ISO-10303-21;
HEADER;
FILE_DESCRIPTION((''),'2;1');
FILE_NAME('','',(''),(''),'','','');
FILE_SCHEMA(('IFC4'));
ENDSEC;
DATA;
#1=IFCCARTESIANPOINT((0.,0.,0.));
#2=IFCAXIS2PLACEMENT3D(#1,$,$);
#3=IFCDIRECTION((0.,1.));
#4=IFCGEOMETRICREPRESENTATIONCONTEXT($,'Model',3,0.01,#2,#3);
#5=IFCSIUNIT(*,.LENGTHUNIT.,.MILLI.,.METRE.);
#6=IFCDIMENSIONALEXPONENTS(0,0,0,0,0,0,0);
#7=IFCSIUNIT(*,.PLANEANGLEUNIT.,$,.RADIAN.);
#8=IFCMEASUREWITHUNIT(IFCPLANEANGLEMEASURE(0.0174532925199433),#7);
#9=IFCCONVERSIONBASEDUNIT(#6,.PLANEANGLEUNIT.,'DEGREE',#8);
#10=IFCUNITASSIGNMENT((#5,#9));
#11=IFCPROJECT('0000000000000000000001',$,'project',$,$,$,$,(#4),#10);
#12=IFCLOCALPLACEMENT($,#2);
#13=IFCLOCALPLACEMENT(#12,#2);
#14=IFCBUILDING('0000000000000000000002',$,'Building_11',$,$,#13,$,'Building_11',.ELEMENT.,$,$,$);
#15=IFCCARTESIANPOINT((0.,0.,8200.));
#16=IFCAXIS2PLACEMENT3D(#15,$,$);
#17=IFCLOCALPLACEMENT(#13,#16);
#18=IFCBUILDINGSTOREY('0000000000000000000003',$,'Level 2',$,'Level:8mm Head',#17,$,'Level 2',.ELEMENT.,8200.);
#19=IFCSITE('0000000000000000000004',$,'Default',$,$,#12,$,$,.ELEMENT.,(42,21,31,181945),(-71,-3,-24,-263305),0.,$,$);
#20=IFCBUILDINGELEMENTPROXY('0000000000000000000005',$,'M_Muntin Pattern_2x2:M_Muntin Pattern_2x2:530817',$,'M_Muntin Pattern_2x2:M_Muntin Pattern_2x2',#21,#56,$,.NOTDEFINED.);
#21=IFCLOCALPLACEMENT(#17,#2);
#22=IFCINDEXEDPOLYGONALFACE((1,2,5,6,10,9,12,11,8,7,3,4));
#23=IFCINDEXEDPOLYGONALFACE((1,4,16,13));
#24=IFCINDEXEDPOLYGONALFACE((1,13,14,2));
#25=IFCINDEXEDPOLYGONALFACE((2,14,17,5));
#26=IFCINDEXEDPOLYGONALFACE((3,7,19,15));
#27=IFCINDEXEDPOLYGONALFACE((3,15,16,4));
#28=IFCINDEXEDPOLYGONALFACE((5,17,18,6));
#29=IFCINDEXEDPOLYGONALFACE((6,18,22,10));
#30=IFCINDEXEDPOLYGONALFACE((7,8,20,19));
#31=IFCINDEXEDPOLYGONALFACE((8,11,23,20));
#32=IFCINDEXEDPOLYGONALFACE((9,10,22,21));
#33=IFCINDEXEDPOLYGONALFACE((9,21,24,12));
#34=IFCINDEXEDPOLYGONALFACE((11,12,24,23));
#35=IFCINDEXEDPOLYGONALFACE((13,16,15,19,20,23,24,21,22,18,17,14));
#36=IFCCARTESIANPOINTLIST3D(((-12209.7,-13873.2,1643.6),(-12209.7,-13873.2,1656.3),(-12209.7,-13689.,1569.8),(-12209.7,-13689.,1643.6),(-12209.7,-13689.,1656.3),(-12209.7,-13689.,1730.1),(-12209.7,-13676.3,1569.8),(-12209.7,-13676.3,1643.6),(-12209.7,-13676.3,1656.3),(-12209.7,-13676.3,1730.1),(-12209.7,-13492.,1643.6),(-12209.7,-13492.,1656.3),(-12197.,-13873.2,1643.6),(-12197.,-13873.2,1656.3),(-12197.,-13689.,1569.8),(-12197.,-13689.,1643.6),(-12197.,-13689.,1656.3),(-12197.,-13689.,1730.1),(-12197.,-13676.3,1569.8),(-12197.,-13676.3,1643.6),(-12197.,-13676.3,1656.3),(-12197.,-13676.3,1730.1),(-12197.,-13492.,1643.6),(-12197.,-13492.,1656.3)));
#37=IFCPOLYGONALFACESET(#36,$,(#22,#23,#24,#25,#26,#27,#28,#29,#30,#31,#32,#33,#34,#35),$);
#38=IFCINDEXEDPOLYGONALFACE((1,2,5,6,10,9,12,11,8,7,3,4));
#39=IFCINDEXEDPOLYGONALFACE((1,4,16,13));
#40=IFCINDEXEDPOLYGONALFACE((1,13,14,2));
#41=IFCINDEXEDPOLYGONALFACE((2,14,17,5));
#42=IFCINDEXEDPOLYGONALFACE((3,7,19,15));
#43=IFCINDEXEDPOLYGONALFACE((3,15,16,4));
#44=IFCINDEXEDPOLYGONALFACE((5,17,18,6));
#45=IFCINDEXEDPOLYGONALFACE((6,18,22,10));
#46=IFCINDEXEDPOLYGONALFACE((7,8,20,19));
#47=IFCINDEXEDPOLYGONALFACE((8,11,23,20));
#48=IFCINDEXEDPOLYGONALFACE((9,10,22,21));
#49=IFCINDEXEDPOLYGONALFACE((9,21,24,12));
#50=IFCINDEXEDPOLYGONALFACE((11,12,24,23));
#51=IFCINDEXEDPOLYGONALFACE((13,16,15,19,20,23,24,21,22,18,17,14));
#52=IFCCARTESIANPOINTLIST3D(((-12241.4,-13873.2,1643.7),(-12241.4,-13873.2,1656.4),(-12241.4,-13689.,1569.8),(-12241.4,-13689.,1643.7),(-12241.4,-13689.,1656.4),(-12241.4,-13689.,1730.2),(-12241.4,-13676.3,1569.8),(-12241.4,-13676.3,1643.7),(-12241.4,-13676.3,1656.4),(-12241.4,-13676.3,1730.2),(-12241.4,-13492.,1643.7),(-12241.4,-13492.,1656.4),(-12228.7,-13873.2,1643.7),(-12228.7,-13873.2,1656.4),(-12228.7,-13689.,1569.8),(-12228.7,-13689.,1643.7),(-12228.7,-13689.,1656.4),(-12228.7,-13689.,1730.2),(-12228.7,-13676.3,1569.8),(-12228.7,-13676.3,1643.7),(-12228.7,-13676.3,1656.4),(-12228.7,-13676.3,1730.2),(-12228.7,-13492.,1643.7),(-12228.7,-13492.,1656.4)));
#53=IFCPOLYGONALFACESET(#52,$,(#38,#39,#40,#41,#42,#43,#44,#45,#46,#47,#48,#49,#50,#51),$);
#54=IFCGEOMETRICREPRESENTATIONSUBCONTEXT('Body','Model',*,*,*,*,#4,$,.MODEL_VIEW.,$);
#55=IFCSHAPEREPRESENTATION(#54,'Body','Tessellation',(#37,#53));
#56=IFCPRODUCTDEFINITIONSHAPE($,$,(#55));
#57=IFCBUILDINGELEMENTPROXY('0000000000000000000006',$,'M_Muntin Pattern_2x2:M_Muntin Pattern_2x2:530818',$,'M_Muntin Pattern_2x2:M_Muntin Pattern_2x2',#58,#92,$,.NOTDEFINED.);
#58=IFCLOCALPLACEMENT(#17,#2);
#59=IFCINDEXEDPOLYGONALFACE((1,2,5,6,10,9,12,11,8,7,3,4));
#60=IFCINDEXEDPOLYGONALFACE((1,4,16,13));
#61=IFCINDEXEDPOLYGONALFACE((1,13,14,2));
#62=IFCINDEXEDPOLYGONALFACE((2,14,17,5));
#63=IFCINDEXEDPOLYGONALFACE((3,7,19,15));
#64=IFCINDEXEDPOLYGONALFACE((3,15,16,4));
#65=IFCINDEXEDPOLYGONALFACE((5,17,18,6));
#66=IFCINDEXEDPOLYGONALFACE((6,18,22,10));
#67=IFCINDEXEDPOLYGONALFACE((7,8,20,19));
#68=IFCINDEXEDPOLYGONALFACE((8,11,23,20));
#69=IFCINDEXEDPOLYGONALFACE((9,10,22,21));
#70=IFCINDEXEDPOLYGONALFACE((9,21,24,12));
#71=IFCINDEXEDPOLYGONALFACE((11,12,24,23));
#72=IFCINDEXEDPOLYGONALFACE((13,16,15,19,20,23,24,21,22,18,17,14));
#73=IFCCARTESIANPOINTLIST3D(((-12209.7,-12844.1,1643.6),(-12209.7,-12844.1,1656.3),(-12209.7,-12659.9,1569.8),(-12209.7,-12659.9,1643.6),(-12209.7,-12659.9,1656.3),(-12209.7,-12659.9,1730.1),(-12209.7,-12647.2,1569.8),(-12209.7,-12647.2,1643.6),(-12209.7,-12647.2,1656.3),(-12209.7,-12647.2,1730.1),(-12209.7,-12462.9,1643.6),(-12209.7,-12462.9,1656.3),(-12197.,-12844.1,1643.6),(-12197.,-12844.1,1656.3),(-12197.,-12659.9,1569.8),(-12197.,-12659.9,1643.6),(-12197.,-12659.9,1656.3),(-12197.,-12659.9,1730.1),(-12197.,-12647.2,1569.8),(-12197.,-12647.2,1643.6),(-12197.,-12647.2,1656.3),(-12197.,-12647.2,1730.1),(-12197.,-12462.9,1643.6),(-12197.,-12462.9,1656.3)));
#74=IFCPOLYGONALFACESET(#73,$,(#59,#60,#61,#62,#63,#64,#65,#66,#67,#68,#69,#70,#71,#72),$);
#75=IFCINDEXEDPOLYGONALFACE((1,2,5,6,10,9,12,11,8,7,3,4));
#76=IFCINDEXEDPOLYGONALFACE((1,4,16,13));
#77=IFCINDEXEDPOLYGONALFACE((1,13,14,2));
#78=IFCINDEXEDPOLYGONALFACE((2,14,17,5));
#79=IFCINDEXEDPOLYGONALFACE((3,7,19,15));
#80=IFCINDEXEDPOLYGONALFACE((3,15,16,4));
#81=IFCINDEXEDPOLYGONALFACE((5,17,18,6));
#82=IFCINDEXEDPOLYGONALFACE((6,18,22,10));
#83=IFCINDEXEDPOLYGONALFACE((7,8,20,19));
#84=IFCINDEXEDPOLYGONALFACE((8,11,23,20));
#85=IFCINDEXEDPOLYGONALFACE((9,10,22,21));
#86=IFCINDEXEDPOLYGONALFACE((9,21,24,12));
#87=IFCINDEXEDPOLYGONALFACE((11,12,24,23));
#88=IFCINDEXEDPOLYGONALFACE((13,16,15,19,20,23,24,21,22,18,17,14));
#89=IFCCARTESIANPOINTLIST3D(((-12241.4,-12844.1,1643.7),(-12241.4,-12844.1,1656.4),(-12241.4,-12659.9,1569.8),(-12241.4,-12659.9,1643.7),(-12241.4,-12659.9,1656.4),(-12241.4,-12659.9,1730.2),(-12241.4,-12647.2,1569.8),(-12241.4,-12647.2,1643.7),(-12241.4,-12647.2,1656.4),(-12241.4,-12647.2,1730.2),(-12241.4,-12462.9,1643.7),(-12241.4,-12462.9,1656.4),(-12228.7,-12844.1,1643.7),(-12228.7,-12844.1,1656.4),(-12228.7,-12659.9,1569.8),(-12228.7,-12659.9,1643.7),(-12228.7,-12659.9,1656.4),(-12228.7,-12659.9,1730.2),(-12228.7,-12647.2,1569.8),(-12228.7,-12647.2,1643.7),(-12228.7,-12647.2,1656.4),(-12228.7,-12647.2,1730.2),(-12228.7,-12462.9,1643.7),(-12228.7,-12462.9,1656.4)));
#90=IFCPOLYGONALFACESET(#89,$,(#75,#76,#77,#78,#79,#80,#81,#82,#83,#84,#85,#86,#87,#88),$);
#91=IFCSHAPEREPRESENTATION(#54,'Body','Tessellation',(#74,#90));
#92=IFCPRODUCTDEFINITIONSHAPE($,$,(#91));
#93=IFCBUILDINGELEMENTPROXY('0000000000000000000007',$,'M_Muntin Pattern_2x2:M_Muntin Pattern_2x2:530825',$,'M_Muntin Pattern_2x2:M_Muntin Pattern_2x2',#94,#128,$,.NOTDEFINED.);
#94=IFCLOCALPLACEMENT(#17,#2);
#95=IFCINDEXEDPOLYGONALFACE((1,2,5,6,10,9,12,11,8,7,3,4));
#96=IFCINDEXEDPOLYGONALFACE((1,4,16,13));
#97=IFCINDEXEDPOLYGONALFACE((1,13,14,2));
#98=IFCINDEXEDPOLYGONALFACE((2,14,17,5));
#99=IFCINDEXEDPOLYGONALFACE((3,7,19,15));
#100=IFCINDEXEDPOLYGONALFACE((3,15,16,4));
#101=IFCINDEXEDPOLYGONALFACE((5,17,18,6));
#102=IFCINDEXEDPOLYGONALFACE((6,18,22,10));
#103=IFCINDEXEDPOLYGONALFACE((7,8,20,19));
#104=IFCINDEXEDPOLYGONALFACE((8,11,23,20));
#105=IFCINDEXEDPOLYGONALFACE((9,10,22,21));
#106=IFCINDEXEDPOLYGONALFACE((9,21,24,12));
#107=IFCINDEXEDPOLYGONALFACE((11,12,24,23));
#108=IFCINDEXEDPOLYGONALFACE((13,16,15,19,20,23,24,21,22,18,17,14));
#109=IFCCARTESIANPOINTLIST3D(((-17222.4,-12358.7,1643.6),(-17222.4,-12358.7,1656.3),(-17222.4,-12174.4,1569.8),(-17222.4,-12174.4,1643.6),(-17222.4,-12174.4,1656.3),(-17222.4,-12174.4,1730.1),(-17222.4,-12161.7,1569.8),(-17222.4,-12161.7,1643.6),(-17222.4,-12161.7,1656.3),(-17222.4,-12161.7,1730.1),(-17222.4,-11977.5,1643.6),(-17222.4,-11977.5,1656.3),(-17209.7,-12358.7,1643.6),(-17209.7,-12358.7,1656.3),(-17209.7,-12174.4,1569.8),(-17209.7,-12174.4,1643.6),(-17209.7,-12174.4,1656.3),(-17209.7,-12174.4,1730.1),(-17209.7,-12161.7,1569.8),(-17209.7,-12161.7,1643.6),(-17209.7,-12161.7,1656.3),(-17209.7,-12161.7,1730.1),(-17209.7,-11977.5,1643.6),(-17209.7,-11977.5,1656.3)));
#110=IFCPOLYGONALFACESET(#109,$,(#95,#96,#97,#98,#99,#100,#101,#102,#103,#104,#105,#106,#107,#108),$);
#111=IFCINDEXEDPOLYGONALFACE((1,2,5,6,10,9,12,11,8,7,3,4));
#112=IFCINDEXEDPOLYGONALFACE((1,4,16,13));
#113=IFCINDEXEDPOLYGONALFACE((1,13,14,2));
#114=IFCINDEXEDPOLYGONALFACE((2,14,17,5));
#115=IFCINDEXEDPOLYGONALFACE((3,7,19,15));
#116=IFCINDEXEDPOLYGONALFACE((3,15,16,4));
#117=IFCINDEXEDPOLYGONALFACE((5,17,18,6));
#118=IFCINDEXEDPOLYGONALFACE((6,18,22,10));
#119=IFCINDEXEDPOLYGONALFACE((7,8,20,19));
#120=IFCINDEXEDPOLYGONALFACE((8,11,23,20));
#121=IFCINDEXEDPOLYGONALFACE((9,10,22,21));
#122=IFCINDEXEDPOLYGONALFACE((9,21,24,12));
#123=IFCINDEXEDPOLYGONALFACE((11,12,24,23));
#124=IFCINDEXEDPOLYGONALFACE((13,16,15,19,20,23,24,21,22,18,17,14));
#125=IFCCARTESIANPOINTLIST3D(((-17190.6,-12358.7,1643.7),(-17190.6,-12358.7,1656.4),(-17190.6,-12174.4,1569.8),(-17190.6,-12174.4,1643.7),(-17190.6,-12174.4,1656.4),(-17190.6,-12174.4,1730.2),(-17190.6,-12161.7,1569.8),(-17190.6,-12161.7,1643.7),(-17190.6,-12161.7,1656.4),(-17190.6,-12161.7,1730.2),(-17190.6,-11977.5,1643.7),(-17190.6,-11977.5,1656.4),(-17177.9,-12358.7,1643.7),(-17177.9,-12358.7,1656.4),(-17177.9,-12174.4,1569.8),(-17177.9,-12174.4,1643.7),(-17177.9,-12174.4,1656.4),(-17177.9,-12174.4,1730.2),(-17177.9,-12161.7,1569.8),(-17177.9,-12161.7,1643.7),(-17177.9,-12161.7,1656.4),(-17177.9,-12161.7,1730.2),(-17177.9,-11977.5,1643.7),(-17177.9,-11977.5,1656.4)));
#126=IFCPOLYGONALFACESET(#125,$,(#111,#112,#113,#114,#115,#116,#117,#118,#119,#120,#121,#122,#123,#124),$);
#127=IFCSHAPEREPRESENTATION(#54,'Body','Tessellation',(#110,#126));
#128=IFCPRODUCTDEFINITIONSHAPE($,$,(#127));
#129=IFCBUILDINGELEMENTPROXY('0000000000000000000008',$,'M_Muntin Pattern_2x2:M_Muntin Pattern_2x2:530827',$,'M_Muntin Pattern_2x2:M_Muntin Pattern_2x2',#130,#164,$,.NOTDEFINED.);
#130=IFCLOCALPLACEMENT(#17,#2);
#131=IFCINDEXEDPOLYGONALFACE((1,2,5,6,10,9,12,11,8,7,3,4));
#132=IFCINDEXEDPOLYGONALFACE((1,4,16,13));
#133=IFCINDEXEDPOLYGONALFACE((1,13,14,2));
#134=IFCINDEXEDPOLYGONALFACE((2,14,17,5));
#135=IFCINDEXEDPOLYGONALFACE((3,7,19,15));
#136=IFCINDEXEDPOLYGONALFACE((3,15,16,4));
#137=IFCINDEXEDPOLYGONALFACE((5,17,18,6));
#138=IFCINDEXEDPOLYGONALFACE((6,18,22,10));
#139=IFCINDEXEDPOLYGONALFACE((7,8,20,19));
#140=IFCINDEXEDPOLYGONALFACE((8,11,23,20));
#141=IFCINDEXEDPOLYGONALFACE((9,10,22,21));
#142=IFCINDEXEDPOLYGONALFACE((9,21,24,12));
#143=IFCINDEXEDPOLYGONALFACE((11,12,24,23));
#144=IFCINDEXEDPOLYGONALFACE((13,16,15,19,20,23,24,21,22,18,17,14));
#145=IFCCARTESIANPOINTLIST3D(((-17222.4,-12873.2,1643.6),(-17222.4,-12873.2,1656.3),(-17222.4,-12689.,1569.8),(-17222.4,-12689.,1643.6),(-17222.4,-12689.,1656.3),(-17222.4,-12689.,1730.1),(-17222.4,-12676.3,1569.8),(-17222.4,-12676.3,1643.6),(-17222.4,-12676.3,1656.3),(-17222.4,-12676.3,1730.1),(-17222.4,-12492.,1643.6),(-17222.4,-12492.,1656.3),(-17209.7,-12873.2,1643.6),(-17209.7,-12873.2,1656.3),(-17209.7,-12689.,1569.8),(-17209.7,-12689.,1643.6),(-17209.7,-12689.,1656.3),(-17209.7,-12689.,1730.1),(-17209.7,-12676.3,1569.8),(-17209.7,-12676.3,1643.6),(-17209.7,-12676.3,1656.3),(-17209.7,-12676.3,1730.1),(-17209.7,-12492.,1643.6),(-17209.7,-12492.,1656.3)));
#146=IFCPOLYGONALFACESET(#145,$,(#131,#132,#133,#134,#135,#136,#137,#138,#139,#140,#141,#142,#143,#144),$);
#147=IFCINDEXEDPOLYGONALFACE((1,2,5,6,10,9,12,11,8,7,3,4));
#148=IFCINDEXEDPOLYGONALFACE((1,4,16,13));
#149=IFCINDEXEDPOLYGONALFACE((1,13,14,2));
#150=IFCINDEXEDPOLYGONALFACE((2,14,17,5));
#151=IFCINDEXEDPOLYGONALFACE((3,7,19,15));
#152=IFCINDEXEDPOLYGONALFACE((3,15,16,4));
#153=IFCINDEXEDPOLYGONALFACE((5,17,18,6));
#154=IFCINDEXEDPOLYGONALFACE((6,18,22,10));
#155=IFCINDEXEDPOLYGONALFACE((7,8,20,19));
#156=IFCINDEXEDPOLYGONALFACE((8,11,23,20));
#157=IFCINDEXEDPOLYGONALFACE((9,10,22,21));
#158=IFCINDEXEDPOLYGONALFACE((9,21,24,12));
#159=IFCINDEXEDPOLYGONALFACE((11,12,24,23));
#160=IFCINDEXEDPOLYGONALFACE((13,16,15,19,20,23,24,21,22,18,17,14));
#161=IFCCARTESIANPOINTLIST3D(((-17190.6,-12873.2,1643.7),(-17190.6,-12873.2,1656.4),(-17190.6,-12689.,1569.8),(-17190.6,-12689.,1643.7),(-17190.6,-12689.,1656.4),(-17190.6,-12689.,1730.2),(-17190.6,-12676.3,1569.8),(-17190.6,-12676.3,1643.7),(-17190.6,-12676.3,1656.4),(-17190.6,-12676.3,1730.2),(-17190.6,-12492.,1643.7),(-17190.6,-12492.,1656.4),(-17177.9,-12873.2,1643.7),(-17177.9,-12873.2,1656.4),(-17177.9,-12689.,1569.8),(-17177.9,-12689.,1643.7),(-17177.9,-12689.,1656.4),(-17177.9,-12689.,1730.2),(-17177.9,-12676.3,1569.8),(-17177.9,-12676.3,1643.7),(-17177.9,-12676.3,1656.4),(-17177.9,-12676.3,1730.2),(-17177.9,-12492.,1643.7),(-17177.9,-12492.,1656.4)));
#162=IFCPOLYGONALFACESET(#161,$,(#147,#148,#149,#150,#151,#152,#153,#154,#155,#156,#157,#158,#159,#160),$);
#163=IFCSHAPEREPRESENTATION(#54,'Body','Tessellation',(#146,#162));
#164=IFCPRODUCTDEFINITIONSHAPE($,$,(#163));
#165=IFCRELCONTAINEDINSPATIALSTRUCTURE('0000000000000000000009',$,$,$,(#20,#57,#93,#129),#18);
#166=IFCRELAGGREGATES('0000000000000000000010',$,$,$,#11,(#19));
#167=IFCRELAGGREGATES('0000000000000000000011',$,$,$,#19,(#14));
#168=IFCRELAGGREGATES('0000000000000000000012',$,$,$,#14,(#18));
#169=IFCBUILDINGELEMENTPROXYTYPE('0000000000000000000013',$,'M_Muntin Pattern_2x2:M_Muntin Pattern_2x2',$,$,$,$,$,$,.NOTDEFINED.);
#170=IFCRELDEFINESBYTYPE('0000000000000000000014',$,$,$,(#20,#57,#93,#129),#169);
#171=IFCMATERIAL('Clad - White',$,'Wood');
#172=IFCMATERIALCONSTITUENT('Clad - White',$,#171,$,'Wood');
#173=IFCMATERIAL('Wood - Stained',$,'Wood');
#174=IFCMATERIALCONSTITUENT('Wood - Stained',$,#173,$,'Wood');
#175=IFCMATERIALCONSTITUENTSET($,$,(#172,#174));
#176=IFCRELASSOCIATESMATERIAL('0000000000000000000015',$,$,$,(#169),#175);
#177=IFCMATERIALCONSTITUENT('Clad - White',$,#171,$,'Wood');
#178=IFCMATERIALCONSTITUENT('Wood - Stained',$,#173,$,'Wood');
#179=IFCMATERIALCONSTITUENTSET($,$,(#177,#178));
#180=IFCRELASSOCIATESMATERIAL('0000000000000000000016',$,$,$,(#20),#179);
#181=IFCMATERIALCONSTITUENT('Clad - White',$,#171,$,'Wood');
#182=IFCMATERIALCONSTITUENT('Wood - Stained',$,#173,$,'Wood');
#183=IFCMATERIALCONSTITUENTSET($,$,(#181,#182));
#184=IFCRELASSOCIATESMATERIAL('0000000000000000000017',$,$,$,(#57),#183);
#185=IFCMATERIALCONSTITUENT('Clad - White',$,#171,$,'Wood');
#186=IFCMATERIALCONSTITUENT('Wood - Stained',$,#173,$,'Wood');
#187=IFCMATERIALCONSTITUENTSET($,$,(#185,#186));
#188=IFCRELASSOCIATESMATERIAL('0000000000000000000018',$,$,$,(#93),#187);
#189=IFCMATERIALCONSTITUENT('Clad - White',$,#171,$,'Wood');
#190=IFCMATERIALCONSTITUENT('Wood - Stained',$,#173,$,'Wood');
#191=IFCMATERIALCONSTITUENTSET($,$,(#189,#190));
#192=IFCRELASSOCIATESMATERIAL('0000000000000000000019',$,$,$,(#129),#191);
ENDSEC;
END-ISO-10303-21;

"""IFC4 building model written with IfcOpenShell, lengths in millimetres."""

from ifc_helpers import new_model, entity, si_unit, converted_unit, direction, frame, origin, place, context, subcontext, project, spatial, indexed_curve, outline, extrude, source, transform, mapped, material, constituent, constituent_set, type_object, type_shapes, element, save


model = new_model("IFC4")

# Units and contexts
model_context = context("Model", 3, precision=0.01, world=origin(), true_north=direction((0.0, 1.0)))
body_context = subcontext(model_context, "Body", "Model", "MODEL_VIEW")
ifc_project = project(units=[si_unit("LENGTHUNIT", "METRE", prefix="MILLI"), converted_unit("PLANEANGLEUNIT", "DEGREE", entity("IfcPlaneAngleMeasure", 0.0174532925199433), si_unit("PLANEANGLEUNIT", "RADIAN"), dimensions=[0, 0, 0, 0, 0, 0, 0])], contexts=[model_context])

# Site, building, storey
site_placement = place(None, origin())
site = spatial("IfcSite", under=ifc_project, at=site_placement, Name="Default", CompositionType="ELEMENT", RefLatitude=(42, 21, 31, 181945), RefLongitude=(-71, -3, -24, -263305), RefElevation=0.0)
building_placement = place(site_placement, origin())
building = spatial("IfcBuilding", under=site, at=building_placement, Name="Building_11", LongName="Building_11", CompositionType="ELEMENT")
storey_placement = place(building_placement, frame((0.0, 0.0, 8200.0)))
storey = spatial("IfcBuildingStorey", under=building, at=storey_placement, Name="Level 2", ObjectType="Level:8mm Head", LongName="Level 2", CompositionType="ELEMENT", Elevation=8200.0)

# Building element proxies
ifc_material_1 = material(Name="Clad - White", Category="Wood")
ifc_material_2 = material(Name="Wood - Stained", Category="Wood")
ifc_constituent_1 = constituent(ifc_material_1, Name="Clad - White", Category="Wood")
ifc_constituent_2 = constituent(ifc_material_2, Name="Wood - Stained", Category="Wood")
ifc_constituent_set_1 = constituent_set(constituents=[ifc_constituent_1, ifc_constituent_2])
building_element_proxy_type_1 = type_object("IfcBuildingElementProxyType", Name="M_Muntin Pattern_2x2:M_Muntin Pattern_2x2", PredefinedType="NOTDEFINED", material=ifc_constituent_set_1)
shared_shape_1 = source(origin(), body_context, "Body", "SweptSolid", [
    extrude(outline(indexed_curve([(6.4, -6.4), (80.1, -6.4), (80.1, 6.3), (6.4, 6.3), (6.4, 190.6), (-6.3, 190.6), (-6.3, 6.3), (-80.2, 6.3), (-80.2, -6.4), (-6.3, -6.4), (-6.3, -190.6), (6.4, -190.6), (6.4, -6.4)], self_intersect=False)), frame((0.0, 9.5, 80.1), z_axis=(0.0, 1.0, 0.0), x_axis=(0.0, 0.0, 1.0)), (0.0, 0.0, 1.0), 12.7),
    extrude(outline(indexed_curve([(6.4, -6.4), (80.2, -6.4), (80.2, 6.3), (6.4, 6.3), (6.4, 190.6), (-6.3, 190.6), (-6.3, 6.3), (-80.2, 6.3), (-80.2, -6.4), (-6.3, -6.4), (-6.3, -190.6), (6.4, -190.6), (6.4, -6.4)], self_intersect=False)), frame((0.0, -22.2, 80.2), z_axis=(0.0, 1.0, 0.0), x_axis=(0.0, 0.0, 1.0)), (0.0, 0.0, 1.0), 12.7),
])
type_shapes(building_element_proxy_type_1, [shared_shape_1])
ifc_constituent_3 = constituent(ifc_material_1, Name="Clad - White", Category="Wood")
ifc_constituent_4 = constituent(ifc_material_2, Name="Wood - Stained", Category="Wood")
ifc_constituent_set_2 = constituent_set(constituents=[ifc_constituent_3, ifc_constituent_4])
proxy_1_placement = place(storey_placement, frame((-12219.2, -13682.6, 1569.8), z_axis=(0.0, 0.0, 1.0), x_axis=(0.0, -1.0, 0.0)))
element("IfcBuildingElementProxy", 1, at=proxy_1_placement, inside=storey, type_object=building_element_proxy_type_1, material=ifc_constituent_set_2, Name="M_Muntin Pattern_2x2:M_Muntin Pattern_2x2:530817", ObjectType="M_Muntin Pattern_2x2:M_Muntin Pattern_2x2", PredefinedType="NOTDEFINED", context=body_context, shape_type="MappedRepresentation", body=[
    mapped(shared_shape_1, transform((0.0, 0.0, 0.0), scale=1.0)),
])
ifc_constituent_5 = constituent(ifc_material_1, Name="Clad - White", Category="Wood")
ifc_constituent_6 = constituent(ifc_material_2, Name="Wood - Stained", Category="Wood")
ifc_constituent_set_3 = constituent_set(constituents=[ifc_constituent_5, ifc_constituent_6])
proxy_2_placement = place(storey_placement, frame((-12219.2, -12653.5, 1569.8), z_axis=(0.0, 0.0, 1.0), x_axis=(0.0, -1.0, 0.0)))
element("IfcBuildingElementProxy", 2, at=proxy_2_placement, inside=storey, type_object=building_element_proxy_type_1, material=ifc_constituent_set_3, Name="M_Muntin Pattern_2x2:M_Muntin Pattern_2x2:530818", ObjectType="M_Muntin Pattern_2x2:M_Muntin Pattern_2x2", PredefinedType="NOTDEFINED", context=body_context, shape_type="MappedRepresentation", body=[
    mapped(shared_shape_1, transform((0.0, 0.0, 0.0), scale=1.0)),
])
ifc_constituent_7 = constituent(ifc_material_1, Name="Clad - White", Category="Wood")
ifc_constituent_8 = constituent(ifc_material_2, Name="Wood - Stained", Category="Wood")
ifc_constituent_set_4 = constituent_set(constituents=[ifc_constituent_7, ifc_constituent_8])
proxy_3_placement = place(storey_placement, frame((-17200.2, -12168.1, 1569.8), z_axis=(0.0, 0.0, 1.0), x_axis=(0.0, 1.0, 0.0)))
element("IfcBuildingElementProxy", 3, at=proxy_3_placement, inside=storey, type_object=building_element_proxy_type_1, material=ifc_constituent_set_4, Name="M_Muntin Pattern_2x2:M_Muntin Pattern_2x2:530825", ObjectType="M_Muntin Pattern_2x2:M_Muntin Pattern_2x2", PredefinedType="NOTDEFINED", context=body_context, shape_type="MappedRepresentation", body=[
    mapped(shared_shape_1, transform((0.0, 0.0, 0.0), scale=1.0)),
])
ifc_constituent_9 = constituent(ifc_material_1, Name="Clad - White", Category="Wood")
ifc_constituent_10 = constituent(ifc_material_2, Name="Wood - Stained", Category="Wood")
ifc_constituent_set_5 = constituent_set(constituents=[ifc_constituent_9, ifc_constituent_10])
proxy_4_placement = place(storey_placement, frame((-17200.2, -12682.6, 1569.8), z_axis=(0.0, 0.0, 1.0), x_axis=(0.0, 1.0, 0.0)))
element("IfcBuildingElementProxy", 4, at=proxy_4_placement, inside=storey, type_object=building_element_proxy_type_1, material=ifc_constituent_set_5, Name="M_Muntin Pattern_2x2:M_Muntin Pattern_2x2:530827", ObjectType="M_Muntin Pattern_2x2:M_Muntin Pattern_2x2", PredefinedType="NOTDEFINED", context=body_context, shape_type="MappedRepresentation", body=[
    mapped(shared_shape_1, transform((0.0, 0.0, 0.0), scale=1.0)),
])

save(model, "model.ifc")
